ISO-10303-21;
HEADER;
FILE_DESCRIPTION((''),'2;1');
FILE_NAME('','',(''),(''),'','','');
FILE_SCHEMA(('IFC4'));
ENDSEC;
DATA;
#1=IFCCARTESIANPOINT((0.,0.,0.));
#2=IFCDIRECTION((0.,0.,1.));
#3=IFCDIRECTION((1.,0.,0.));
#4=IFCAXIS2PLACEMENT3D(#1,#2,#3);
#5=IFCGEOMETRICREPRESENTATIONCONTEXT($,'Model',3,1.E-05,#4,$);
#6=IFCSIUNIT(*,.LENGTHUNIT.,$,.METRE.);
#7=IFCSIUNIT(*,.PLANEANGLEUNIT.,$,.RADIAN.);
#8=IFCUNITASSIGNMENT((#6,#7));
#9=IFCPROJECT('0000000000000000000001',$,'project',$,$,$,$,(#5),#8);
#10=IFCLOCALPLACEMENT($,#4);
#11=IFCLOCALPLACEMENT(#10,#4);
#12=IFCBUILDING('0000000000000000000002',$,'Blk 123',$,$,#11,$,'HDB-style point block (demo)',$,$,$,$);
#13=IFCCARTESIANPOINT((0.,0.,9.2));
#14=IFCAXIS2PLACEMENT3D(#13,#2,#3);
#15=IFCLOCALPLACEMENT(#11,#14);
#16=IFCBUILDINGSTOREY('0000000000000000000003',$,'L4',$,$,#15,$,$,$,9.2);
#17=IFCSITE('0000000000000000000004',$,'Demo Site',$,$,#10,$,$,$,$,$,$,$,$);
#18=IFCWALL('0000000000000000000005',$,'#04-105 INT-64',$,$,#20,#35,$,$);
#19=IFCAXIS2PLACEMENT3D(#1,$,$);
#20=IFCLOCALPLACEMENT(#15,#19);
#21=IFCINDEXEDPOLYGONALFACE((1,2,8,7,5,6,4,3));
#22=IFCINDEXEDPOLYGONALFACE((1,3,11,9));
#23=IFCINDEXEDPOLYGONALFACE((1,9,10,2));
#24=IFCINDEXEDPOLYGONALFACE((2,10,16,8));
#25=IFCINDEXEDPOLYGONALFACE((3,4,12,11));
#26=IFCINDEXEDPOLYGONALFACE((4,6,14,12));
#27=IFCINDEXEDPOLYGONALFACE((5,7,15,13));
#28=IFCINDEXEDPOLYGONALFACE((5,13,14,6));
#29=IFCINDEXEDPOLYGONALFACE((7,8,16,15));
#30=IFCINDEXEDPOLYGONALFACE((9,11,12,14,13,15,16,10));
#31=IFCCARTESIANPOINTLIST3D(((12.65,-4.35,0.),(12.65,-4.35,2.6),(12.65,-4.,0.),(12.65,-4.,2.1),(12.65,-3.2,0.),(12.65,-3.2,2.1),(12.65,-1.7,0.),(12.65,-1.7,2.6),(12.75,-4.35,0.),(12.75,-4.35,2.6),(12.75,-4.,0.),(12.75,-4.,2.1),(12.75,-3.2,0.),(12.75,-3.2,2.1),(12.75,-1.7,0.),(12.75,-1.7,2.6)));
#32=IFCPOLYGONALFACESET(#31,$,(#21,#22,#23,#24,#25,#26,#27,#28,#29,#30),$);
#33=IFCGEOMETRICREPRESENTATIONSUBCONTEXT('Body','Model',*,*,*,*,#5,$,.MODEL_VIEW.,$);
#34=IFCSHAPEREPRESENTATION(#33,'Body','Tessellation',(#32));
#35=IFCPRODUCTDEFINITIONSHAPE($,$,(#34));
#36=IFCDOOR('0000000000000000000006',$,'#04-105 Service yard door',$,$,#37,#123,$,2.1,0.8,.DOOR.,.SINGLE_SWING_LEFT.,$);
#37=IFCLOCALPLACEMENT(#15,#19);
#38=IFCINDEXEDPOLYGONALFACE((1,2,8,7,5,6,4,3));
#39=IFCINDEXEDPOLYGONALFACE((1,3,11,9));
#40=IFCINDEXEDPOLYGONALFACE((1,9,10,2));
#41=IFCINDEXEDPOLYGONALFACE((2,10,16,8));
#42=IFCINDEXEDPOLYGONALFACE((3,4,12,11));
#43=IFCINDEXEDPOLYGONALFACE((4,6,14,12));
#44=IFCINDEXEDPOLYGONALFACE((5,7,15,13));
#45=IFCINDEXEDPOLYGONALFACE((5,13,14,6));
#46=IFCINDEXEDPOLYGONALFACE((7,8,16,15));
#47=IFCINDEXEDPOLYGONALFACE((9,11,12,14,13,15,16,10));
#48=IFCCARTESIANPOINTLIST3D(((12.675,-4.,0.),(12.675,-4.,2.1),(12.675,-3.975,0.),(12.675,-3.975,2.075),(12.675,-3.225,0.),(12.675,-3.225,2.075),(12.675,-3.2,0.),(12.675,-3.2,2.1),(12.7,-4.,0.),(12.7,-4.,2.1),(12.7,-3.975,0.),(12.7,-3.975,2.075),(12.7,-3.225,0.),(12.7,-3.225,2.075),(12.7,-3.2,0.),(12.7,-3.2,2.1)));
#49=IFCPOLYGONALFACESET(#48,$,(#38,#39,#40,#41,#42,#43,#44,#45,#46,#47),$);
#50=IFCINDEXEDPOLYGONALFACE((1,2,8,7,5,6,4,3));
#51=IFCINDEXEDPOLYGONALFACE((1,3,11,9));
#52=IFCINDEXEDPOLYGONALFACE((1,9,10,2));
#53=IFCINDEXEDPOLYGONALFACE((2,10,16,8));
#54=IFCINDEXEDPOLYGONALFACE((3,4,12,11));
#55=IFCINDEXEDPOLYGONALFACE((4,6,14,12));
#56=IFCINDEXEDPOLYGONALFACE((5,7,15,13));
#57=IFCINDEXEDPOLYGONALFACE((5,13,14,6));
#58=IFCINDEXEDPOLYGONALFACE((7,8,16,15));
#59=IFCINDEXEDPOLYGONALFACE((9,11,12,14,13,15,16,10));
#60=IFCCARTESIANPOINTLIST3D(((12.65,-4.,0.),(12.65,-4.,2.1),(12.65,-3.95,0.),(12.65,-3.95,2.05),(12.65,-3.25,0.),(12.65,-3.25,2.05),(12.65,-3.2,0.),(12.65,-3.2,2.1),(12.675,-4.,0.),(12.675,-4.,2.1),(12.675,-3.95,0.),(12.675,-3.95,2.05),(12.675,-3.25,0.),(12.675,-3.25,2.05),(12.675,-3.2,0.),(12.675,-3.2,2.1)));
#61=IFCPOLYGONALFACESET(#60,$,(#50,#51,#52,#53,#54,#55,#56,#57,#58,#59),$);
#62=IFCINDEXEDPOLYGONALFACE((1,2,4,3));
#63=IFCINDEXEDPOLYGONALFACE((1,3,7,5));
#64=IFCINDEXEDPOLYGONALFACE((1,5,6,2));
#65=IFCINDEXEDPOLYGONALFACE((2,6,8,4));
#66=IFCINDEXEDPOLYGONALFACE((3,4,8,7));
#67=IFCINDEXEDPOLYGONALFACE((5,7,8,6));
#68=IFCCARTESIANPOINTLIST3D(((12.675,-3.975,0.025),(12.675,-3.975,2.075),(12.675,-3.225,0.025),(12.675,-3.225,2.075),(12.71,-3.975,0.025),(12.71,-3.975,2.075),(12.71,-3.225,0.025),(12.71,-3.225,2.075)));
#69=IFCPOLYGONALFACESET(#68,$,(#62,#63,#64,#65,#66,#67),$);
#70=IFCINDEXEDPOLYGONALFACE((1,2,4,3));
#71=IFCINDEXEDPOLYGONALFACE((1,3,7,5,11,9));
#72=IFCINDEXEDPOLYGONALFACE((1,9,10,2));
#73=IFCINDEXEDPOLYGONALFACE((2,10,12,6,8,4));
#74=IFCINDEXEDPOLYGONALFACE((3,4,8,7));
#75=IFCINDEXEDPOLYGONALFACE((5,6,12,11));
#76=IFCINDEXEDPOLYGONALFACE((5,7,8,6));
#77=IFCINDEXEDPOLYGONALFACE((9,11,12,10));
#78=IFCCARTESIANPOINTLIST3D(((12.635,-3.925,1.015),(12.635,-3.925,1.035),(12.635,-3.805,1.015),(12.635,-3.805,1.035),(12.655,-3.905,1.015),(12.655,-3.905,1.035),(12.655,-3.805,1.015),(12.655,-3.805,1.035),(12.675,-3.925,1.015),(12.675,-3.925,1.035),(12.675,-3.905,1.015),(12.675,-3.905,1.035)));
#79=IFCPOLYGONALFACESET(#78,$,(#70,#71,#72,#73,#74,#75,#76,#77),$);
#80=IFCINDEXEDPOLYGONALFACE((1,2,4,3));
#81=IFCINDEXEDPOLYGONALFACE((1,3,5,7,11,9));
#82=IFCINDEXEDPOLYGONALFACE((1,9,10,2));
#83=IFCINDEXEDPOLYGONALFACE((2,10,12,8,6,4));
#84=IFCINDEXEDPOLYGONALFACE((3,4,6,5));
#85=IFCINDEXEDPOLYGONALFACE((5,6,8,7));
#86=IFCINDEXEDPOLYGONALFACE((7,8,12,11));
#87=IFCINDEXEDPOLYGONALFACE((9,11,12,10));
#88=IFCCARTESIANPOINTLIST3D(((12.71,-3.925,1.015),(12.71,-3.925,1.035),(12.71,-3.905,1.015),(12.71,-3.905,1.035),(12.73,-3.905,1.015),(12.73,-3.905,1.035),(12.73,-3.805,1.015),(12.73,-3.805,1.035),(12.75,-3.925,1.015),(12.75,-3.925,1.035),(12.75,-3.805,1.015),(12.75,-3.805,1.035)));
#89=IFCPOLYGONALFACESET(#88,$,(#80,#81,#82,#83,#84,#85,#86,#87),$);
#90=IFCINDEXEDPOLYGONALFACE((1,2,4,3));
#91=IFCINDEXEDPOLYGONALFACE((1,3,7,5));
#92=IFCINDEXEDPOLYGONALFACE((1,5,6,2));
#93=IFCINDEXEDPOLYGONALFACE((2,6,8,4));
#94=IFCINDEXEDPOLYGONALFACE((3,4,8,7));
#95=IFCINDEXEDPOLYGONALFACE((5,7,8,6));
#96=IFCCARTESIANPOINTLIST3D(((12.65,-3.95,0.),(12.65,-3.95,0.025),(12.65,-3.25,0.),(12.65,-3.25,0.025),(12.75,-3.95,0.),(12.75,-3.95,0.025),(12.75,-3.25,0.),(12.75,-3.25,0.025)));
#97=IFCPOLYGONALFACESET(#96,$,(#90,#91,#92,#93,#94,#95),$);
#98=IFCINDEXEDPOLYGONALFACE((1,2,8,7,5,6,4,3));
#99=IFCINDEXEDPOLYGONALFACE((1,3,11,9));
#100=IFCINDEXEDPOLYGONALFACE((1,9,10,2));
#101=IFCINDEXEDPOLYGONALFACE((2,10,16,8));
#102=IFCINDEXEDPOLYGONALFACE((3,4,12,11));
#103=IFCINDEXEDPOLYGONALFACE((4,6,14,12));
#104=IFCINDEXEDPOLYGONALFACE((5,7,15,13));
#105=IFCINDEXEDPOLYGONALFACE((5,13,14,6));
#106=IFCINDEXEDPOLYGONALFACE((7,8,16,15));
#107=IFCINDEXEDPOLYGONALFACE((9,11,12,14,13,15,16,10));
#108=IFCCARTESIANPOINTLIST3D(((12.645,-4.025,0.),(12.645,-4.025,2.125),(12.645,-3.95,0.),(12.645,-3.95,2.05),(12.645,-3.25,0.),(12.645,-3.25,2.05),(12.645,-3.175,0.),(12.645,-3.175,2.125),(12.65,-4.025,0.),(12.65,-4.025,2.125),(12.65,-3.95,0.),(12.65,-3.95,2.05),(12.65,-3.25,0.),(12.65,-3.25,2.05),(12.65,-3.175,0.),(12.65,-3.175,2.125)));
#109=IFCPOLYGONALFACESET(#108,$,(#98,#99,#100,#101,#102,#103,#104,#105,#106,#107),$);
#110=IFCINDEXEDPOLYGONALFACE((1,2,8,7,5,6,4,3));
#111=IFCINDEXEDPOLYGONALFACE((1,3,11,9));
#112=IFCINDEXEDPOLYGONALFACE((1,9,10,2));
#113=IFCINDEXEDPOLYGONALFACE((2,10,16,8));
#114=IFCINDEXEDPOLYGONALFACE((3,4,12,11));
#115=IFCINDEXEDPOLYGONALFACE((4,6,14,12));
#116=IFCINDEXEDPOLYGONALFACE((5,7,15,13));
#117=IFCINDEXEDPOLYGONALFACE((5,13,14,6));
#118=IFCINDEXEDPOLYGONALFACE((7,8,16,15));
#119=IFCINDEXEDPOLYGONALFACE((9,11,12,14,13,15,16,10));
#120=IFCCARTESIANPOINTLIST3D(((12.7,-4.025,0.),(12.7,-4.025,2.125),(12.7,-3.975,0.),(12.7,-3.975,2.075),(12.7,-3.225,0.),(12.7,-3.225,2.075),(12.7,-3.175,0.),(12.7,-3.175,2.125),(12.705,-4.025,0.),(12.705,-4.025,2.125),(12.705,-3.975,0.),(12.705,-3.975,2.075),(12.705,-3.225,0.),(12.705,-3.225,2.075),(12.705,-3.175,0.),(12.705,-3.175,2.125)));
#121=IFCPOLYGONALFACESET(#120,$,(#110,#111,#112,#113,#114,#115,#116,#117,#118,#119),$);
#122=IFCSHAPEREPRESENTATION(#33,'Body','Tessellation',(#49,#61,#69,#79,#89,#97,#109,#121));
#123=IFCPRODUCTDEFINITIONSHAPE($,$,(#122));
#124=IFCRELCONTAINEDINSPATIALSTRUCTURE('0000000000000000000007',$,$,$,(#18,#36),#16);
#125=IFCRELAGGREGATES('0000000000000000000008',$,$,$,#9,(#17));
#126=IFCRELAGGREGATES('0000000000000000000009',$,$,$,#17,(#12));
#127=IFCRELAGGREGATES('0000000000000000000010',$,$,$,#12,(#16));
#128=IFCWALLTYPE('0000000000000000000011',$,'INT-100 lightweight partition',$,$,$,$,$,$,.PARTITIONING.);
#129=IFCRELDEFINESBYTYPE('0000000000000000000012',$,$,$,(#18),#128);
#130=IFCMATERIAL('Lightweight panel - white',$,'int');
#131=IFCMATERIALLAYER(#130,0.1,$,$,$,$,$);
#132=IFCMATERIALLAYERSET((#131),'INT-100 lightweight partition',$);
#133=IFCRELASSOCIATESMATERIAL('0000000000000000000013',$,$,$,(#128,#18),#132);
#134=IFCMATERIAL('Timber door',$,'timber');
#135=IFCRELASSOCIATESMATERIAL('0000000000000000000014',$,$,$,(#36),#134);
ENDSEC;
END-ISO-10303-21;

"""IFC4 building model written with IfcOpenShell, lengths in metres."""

from ifc_helpers import new_model, si_unit, frame, origin_with_axes, place, context, subcontext, project, spatial, line, indexed_curve, outline, extrude, material, layer, layer_set, layer_usage, type_object, element, fill, save


model = new_model("IFC4")

# Units and contexts
model_context = context("Model", 3, precision=1e-05, world=origin_with_axes())
body_context = subcontext(model_context, "Body", "Model", "MODEL_VIEW")
ifc_project = project(units=[si_unit("LENGTHUNIT", "METRE"), si_unit("PLANEANGLEUNIT", "RADIAN")], contexts=[model_context])

# Site, building, storey
site_placement = place(None, origin_with_axes())
site = spatial("IfcSite", under=ifc_project, at=site_placement, Name="Demo Site")
building_placement = place(site_placement, origin_with_axes())
building = spatial("IfcBuilding", under=site, at=building_placement, Name="Blk 123", LongName="HDB-style point block (demo)")
storey_placement = place(building_placement, frame((0.0, 0.0, 9.2), z_axis=(0.0, 0.0, 1.0), x_axis=(1.0, 0.0, 0.0)))
storey = spatial("IfcBuildingStorey", under=building, at=storey_placement, Name="L4", Elevation=9.2)

# Shared definitions
ifc_material_1 = material(Name="Timber door", Category="timber")

# Wall, opening, door
ifc_material_2 = material(Name="Lightweight panel - white", Category="int")
ifc_layer_1 = layer(ifc_material_2, 0.1)
ifc_layer_set_1 = layer_set([ifc_layer_1], Name="INT-100 lightweight partition")
ifc_layer_usage_1 = layer_usage(ifc_layer_set_1, "AXIS2", "POSITIVE", -0.05)
wall_type_1 = type_object("IfcWallType", Name="INT-100 lightweight partition", PredefinedType="PARTITIONING", material=ifc_layer_set_1)
wall_1_placement = place(storey_placement, frame((12.7, -1.7, 0.0), z_axis=(0.0, 0.0, 1.0), x_axis=(0.0, -1.0, 0.0)))
wall_1 = element("IfcWall", 1, at=wall_1_placement, inside=storey, type_object=wall_type_1, material=ifc_layer_usage_1, Name="#04-105 INT-64", context=body_context, shape_type="SweptSolid", body=[
    extrude(outline(indexed_curve([(0.0, 0.0), (0.0, 0.1), (2.65, 0.1), (2.65, 0.0), (0.0, 0.0)], self_intersect=False)), frame((0.0, -0.05, 0.0), z_axis=(0.0, 0.0, 1.0), x_axis=(1.0, 0.0, 0.0)), (0.0, 0.0, 1.0), 2.6),
])
opening_1_placement = place(wall_1_placement, frame((1.5, -0.15, 0.0), z_axis=(0.0, 0.0, 1.0), x_axis=(1.0, 0.0, 0.0)))
opening_1 = element("IfcOpeningElement", 2, at=opening_1_placement, cuts=wall_1, context=body_context, shape_type="SweptSolid", body=[
    extrude(outline(indexed_curve([(0.0, 0.0), (0.0, 0.3), (0.8, 0.3), (0.8, 0.0), (0.0, 0.0)], self_intersect=False)), origin_with_axes(), (0.0, 0.0, 1.0), 2.1),
])
door_1_placement = place(opening_1_placement, frame((0.0, 0.1, 0.0), z_axis=(0.0, 0.0, 1.0), x_axis=(1.0, 0.0, 0.0)))
door_1 = element("IfcDoor", 3, at=door_1_placement, inside=storey, material=ifc_material_1, Name="#04-105 Service yard door", OperationType="SINGLE_SWING_LEFT", OverallHeight=2.1, OverallWidth=0.8, PredefinedType="DOOR", context=body_context, shape_type="SweptSolid", body=[
    extrude(outline(indexed_curve([(0.0, 0.0), (0.0, 2.1), (0.8, 2.1), (0.8, 0.0), (0.775, 0.0), (0.775, 2.075), (0.025, 2.075), (0.025, 0.0)], segments=[line(1, 2, 3, 4, 5, 6, 7, 8, 1)])), frame((0.0, 0.025, 0.0), z_axis=(0.0, -1.0, 0.0), x_axis=(1.0, 0.0, 0.0)), (0.0, 0.0, -1.0), 0.025),
    extrude(outline(indexed_curve([(0.0, 0.0), (0.0, 2.1), (0.8, 2.1), (0.8, 0.0), (0.75, 0.0), (0.75, 2.05), (0.05, 2.05), (0.05, 0.0)], segments=[line(1, 2, 3, 4, 5, 6, 7, 8, 1)])), frame((0.0, 0.0, 0.0), z_axis=(0.0, -1.0, 0.0), x_axis=(1.0, 0.0, 0.0)), (0.0, 0.0, -1.0), 0.025),
    extrude(outline(indexed_curve([(0.0, 0.0), (0.75, 0.0), (0.75, 0.035), (0.0, 0.035)], segments=[line(1, 2, 3, 4, 1)])), frame((0.025, 0.025, 0.025), z_axis=(0.0, 0.0, 1.0), x_axis=(1.0, 0.0, 0.0)), (0.0, 0.0, 1.0), 2.05),
    extrude(outline(indexed_curve([(0.0, 0.0), (0.0, -0.04), (-0.12, -0.04), (-0.12, -0.02), (-0.02, -0.02), (-0.02, 0.0)], segments=[line(1, 2, 3, 4, 5, 6, 1)])), frame((0.725, 0.025, 1.015), z_axis=(0.0, 0.0, 1.0), x_axis=(1.0, 0.0, 0.0)), (0.0, 0.0, 1.0), 0.02),
    extrude(outline(indexed_curve([(0.0, 0.0), (0.0, 0.04), (-0.12, 0.04), (-0.12, 0.02), (-0.02, 0.02), (-0.02, 0.0)], segments=[line(1, 2, 3, 4, 5, 6, 1)])), frame((0.725, 0.06, 1.015), z_axis=(0.0, 0.0, 1.0), x_axis=(1.0, 0.0, 0.0)), (0.0, 0.0, 1.0), 0.02),
    extrude(outline(indexed_curve([(0.0, 0.0), (0.7, 0.0), (0.7, 0.1), (0.0, 0.1)], segments=[line(1, 2, 3, 4, 1)])), frame((0.05, 0.0, 0.0), z_axis=(0.0, 0.0, 1.0), x_axis=(1.0, 0.0, 0.0)), (0.0, 0.0, 1.0), 0.025),
    extrude(outline(indexed_curve([(0.0, 0.0), (0.0, 2.125), (0.85, 2.125), (0.85, 0.0), (0.775, 0.0), (0.775, 2.05), (0.075, 2.05), (0.075, 0.0)], segments=[line(1, 2, 3, 4, 5, 6, 7, 8, 1)])), frame((-0.025, -0.005, 0.0), z_axis=(0.0, -1.0, 0.0), x_axis=(1.0, 0.0, 0.0)), (0.0, 0.0, -1.0), 0.005),
    extrude(outline(indexed_curve([(0.0, 0.0), (0.0, 2.125), (0.85, 2.125), (0.85, 0.0), (0.8, 0.0), (0.8, 2.075), (0.05, 2.075), (0.05, 0.0)], segments=[line(1, 2, 3, 4, 5, 6, 7, 8, 1)])), frame((-0.025, 0.05, 0.0), z_axis=(0.0, -1.0, 0.0), x_axis=(1.0, 0.0, 0.0)), (0.0, 0.0, -1.0), 0.005),
])
fill(opening_1, door_1)

save(model, "model.ifc")
